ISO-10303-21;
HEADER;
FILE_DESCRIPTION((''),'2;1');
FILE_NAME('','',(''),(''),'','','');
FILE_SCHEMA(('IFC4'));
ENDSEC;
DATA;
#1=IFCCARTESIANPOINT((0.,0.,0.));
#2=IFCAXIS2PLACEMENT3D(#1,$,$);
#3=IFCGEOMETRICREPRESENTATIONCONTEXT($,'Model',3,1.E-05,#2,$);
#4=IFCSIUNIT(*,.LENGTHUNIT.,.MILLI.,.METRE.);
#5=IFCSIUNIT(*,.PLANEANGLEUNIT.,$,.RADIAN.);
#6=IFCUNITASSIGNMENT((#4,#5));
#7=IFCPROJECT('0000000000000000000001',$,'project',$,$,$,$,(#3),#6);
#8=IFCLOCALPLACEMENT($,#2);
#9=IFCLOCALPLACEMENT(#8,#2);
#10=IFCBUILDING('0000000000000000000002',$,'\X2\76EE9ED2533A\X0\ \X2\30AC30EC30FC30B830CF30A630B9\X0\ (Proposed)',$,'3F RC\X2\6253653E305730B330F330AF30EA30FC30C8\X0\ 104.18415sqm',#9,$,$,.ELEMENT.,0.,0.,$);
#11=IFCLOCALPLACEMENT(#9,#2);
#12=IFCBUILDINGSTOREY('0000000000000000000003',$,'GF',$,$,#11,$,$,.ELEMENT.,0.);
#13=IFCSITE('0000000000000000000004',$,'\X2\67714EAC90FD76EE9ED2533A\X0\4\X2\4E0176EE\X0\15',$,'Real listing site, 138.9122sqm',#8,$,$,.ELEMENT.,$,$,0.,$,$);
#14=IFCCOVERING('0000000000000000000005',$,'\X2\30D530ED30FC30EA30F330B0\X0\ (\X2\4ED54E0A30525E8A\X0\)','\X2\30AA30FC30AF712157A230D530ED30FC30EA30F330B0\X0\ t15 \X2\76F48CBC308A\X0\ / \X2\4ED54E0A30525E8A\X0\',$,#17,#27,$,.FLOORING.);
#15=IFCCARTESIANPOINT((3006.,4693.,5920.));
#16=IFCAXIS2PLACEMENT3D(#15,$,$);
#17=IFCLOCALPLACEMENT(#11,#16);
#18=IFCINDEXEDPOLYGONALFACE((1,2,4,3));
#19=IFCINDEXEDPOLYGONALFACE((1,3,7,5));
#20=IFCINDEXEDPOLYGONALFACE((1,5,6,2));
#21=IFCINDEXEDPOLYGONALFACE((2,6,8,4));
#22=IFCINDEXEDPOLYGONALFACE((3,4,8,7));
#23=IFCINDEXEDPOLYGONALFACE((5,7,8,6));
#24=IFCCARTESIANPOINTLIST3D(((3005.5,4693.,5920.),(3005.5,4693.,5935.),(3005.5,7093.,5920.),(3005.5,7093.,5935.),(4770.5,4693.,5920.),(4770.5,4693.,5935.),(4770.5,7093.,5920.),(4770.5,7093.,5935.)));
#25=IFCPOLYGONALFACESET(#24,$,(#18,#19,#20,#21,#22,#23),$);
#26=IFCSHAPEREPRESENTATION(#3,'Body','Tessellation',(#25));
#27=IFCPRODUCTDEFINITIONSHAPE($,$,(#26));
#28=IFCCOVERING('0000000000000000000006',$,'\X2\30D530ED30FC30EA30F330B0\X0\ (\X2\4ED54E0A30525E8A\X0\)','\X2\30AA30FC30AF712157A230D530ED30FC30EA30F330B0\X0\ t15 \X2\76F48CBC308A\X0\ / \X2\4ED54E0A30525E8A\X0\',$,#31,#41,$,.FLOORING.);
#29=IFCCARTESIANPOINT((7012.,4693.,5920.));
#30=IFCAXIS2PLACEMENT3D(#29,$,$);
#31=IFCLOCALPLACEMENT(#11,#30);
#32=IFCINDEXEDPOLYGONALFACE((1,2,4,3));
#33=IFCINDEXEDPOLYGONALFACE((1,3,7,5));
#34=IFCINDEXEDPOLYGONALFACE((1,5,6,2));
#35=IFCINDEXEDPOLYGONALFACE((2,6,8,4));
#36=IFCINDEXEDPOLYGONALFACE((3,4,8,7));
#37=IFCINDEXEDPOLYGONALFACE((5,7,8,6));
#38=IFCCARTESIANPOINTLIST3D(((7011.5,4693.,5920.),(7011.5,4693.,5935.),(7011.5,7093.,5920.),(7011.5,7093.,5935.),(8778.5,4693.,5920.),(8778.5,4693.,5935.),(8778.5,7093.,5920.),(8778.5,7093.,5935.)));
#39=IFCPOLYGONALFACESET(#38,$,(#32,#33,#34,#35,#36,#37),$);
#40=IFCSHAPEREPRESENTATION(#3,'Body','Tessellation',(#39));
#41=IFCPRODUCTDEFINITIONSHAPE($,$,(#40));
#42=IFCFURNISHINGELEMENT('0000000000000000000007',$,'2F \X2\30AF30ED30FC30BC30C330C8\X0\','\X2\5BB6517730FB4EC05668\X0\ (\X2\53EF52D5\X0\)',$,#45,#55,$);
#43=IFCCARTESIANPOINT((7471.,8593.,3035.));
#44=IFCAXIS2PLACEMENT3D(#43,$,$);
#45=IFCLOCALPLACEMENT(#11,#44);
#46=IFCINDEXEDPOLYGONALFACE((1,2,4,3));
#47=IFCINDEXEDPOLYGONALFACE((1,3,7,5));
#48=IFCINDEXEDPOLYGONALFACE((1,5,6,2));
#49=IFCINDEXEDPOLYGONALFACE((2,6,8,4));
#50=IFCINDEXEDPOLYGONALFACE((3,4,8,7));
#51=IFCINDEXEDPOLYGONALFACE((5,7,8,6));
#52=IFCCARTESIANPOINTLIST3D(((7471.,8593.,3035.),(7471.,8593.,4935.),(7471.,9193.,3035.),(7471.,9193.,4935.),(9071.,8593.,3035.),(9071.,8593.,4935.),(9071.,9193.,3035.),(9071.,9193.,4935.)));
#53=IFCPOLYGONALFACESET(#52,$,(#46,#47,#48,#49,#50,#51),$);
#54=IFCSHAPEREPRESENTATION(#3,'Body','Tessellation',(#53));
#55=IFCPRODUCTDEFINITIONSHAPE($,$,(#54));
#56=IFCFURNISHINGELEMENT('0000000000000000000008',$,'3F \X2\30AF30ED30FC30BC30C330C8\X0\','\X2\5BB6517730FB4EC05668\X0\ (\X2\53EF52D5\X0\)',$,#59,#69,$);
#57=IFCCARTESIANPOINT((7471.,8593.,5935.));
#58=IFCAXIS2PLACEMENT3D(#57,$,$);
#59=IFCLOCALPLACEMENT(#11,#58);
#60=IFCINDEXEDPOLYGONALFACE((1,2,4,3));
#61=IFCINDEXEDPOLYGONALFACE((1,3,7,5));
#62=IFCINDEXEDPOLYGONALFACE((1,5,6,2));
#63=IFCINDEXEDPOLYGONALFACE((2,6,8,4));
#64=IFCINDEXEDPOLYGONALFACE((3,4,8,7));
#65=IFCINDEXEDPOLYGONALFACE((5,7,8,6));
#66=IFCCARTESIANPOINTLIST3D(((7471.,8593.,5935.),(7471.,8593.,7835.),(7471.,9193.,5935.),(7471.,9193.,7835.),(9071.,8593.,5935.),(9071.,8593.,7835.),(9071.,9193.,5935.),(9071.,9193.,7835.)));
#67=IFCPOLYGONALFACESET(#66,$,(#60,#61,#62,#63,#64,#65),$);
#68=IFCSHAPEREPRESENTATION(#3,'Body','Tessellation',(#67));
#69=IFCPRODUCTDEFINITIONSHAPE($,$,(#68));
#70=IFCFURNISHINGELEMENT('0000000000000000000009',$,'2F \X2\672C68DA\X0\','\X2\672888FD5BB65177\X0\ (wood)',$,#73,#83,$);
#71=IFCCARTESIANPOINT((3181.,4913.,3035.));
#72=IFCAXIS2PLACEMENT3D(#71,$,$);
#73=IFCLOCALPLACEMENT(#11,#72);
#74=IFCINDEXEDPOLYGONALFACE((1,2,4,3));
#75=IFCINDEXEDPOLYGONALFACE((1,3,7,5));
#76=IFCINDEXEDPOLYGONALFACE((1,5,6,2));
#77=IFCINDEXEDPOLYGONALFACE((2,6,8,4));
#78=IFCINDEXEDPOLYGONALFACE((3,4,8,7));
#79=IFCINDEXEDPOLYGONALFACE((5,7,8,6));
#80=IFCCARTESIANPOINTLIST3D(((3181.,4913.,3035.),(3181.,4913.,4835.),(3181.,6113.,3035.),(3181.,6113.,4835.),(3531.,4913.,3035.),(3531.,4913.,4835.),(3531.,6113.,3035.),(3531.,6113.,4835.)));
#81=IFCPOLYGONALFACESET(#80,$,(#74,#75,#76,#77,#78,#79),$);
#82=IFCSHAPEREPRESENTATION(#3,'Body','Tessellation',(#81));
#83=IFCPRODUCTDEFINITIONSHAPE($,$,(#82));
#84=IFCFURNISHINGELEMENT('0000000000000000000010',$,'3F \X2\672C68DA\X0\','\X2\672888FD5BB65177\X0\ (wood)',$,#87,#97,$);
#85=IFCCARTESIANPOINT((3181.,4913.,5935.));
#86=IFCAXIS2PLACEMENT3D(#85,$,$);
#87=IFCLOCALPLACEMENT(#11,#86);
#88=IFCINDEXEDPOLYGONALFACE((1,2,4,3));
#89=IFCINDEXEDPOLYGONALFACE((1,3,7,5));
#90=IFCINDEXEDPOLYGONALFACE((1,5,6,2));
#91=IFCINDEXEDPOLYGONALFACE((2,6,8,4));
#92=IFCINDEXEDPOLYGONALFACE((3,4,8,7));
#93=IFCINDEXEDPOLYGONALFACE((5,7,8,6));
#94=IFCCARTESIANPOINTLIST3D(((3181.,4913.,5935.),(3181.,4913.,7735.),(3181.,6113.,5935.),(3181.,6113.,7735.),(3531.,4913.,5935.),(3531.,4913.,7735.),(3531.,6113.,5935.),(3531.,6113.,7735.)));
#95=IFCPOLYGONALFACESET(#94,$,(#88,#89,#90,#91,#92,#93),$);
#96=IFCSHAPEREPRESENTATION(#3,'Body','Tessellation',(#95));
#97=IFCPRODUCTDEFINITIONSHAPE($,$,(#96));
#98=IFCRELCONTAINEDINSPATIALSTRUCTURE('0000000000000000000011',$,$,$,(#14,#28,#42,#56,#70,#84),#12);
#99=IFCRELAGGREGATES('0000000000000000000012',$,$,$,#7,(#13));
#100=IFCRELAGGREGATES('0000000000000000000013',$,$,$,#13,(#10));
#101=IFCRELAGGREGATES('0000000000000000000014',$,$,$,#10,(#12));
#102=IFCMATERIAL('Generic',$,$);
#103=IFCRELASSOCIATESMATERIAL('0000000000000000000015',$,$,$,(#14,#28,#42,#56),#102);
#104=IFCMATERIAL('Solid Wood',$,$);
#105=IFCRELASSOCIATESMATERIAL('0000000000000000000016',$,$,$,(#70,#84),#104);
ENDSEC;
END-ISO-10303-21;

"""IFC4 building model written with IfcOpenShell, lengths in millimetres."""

from ifc_helpers import new_model, si_unit, frame, frame_2d, origin, place, context, project, spatial, rectangle, extrude, material, element, save


model = new_model("IFC4")

# Units and contexts
model_context = context("Model", 3, precision=1e-05, world=origin())
ifc_project = project(units=[si_unit("LENGTHUNIT", "METRE", prefix="MILLI"), si_unit("PLANEANGLEUNIT", "RADIAN")], contexts=[model_context])

# Site, building, storey
site_placement = place(None, origin())
site = spatial("IfcSite", under=ifc_project, at=site_placement, Name="東京都目黒区4丁目15", ObjectType="Real listing site, 138.9122sqm", CompositionType="ELEMENT", RefElevation=0.0)
building_placement = place(site_placement, origin())
building = spatial("IfcBuilding", under=site, at=building_placement, Name="目黒区 ガレージハウス (Proposed)", ObjectType="3F RC打放しコンクリート 104.18415sqm", CompositionType="ELEMENT", ElevationOfRefHeight=0.0, ElevationOfTerrain=0.0)
storey_placement = place(building_placement, origin())
storey = spatial("IfcBuildingStorey", under=building, at=storey_placement, Name="GF", CompositionType="ELEMENT", Elevation=0.0)

# Shared definitions
ifc_material_1 = material(Name="Solid Wood")

# Coverings
ifc_material_2 = material(Name="Generic")
covering_1_placement = place(storey_placement, frame((3006.0, 4693.0, 5920.0)))
element("IfcCovering", 1, at=covering_1_placement, inside=storey, material=ifc_material_2, Name="フローリング (仕上げ床)", Description="オーク無垢フローリング t15 直貼り / 仕上げ床", PredefinedType="FLOORING", context=model_context, shape_type="SweptSolid", body=[
    extrude(rectangle(XDim=1765.0, YDim=2400.0, at=frame_2d((882.0, 1200.0))), frame((3006.0, 4693.0, 5920.0)), (0.0, 0.0, 1.0), 15.0),
])
covering_2_placement = place(storey_placement, frame((7012.0, 4693.0, 5920.0)))
element("IfcCovering", 2, at=covering_2_placement, inside=storey, material=ifc_material_2, Name="フローリング (仕上げ床)", Description="オーク無垢フローリング t15 直貼り / 仕上げ床", PredefinedType="FLOORING", context=model_context, shape_type="SweptSolid", body=[
    extrude(rectangle(XDim=1767.0, YDim=2400.0, at=frame_2d((883.0, 1200.0))), frame((7012.0, 4693.0, 5920.0)), (0.0, 0.0, 1.0), 15.0),
])

# Furnishing elements
furnishing_1_placement = place(storey_placement, frame((7471.0, 8593.0, 3035.0)))
element("IfcFurnishingElement", 3, at=furnishing_1_placement, inside=storey, material=ifc_material_2, Name="2F クローゼット", Description="家具・什器 (可動)", context=model_context, shape_type="SweptSolid", body=[
    extrude(rectangle(XDim=1600.0, YDim=600.0, at=frame_2d((800.0, 300.0))), frame((7471.0, 8593.0, 3035.0)), (0.0, 0.0, 1.0), 1900.0),
])
furnishing_2_placement = place(storey_placement, frame((7471.0, 8593.0, 5935.0)))
element("IfcFurnishingElement", 4, at=furnishing_2_placement, inside=storey, material=ifc_material_2, Name="3F クローゼット", Description="家具・什器 (可動)", context=model_context, shape_type="SweptSolid", body=[
    extrude(rectangle(XDim=1600.0, YDim=600.0, at=frame_2d((800.0, 300.0))), frame((7471.0, 8593.0, 5935.0)), (0.0, 0.0, 1.0), 1900.0),
])
furnishing_3_placement = place(storey_placement, frame((3181.0, 4913.0, 3035.0)))
element("IfcFurnishingElement", 5, at=furnishing_3_placement, inside=storey, material=ifc_material_1, Name="2F 本棚", Description="木製家具 (wood)", context=model_context, shape_type="SweptSolid", body=[
    extrude(rectangle(XDim=350.0, YDim=1200.0, at=frame_2d((175.0, 600.0))), frame((3181.0, 4913.0, 3035.0)), (0.0, 0.0, 1.0), 1800.0),
])
furnishing_4_placement = place(storey_placement, frame((3181.0, 4913.0, 5935.0)))
element("IfcFurnishingElement", 6, at=furnishing_4_placement, inside=storey, material=ifc_material_1, Name="3F 本棚", Description="木製家具 (wood)", context=model_context, shape_type="SweptSolid", body=[
    extrude(rectangle(XDim=350.0, YDim=1200.0, at=frame_2d((175.0, 600.0))), frame((3181.0, 4913.0, 5935.0)), (0.0, 0.0, 1.0), 1800.0),
])

save(model, "model.ifc")
